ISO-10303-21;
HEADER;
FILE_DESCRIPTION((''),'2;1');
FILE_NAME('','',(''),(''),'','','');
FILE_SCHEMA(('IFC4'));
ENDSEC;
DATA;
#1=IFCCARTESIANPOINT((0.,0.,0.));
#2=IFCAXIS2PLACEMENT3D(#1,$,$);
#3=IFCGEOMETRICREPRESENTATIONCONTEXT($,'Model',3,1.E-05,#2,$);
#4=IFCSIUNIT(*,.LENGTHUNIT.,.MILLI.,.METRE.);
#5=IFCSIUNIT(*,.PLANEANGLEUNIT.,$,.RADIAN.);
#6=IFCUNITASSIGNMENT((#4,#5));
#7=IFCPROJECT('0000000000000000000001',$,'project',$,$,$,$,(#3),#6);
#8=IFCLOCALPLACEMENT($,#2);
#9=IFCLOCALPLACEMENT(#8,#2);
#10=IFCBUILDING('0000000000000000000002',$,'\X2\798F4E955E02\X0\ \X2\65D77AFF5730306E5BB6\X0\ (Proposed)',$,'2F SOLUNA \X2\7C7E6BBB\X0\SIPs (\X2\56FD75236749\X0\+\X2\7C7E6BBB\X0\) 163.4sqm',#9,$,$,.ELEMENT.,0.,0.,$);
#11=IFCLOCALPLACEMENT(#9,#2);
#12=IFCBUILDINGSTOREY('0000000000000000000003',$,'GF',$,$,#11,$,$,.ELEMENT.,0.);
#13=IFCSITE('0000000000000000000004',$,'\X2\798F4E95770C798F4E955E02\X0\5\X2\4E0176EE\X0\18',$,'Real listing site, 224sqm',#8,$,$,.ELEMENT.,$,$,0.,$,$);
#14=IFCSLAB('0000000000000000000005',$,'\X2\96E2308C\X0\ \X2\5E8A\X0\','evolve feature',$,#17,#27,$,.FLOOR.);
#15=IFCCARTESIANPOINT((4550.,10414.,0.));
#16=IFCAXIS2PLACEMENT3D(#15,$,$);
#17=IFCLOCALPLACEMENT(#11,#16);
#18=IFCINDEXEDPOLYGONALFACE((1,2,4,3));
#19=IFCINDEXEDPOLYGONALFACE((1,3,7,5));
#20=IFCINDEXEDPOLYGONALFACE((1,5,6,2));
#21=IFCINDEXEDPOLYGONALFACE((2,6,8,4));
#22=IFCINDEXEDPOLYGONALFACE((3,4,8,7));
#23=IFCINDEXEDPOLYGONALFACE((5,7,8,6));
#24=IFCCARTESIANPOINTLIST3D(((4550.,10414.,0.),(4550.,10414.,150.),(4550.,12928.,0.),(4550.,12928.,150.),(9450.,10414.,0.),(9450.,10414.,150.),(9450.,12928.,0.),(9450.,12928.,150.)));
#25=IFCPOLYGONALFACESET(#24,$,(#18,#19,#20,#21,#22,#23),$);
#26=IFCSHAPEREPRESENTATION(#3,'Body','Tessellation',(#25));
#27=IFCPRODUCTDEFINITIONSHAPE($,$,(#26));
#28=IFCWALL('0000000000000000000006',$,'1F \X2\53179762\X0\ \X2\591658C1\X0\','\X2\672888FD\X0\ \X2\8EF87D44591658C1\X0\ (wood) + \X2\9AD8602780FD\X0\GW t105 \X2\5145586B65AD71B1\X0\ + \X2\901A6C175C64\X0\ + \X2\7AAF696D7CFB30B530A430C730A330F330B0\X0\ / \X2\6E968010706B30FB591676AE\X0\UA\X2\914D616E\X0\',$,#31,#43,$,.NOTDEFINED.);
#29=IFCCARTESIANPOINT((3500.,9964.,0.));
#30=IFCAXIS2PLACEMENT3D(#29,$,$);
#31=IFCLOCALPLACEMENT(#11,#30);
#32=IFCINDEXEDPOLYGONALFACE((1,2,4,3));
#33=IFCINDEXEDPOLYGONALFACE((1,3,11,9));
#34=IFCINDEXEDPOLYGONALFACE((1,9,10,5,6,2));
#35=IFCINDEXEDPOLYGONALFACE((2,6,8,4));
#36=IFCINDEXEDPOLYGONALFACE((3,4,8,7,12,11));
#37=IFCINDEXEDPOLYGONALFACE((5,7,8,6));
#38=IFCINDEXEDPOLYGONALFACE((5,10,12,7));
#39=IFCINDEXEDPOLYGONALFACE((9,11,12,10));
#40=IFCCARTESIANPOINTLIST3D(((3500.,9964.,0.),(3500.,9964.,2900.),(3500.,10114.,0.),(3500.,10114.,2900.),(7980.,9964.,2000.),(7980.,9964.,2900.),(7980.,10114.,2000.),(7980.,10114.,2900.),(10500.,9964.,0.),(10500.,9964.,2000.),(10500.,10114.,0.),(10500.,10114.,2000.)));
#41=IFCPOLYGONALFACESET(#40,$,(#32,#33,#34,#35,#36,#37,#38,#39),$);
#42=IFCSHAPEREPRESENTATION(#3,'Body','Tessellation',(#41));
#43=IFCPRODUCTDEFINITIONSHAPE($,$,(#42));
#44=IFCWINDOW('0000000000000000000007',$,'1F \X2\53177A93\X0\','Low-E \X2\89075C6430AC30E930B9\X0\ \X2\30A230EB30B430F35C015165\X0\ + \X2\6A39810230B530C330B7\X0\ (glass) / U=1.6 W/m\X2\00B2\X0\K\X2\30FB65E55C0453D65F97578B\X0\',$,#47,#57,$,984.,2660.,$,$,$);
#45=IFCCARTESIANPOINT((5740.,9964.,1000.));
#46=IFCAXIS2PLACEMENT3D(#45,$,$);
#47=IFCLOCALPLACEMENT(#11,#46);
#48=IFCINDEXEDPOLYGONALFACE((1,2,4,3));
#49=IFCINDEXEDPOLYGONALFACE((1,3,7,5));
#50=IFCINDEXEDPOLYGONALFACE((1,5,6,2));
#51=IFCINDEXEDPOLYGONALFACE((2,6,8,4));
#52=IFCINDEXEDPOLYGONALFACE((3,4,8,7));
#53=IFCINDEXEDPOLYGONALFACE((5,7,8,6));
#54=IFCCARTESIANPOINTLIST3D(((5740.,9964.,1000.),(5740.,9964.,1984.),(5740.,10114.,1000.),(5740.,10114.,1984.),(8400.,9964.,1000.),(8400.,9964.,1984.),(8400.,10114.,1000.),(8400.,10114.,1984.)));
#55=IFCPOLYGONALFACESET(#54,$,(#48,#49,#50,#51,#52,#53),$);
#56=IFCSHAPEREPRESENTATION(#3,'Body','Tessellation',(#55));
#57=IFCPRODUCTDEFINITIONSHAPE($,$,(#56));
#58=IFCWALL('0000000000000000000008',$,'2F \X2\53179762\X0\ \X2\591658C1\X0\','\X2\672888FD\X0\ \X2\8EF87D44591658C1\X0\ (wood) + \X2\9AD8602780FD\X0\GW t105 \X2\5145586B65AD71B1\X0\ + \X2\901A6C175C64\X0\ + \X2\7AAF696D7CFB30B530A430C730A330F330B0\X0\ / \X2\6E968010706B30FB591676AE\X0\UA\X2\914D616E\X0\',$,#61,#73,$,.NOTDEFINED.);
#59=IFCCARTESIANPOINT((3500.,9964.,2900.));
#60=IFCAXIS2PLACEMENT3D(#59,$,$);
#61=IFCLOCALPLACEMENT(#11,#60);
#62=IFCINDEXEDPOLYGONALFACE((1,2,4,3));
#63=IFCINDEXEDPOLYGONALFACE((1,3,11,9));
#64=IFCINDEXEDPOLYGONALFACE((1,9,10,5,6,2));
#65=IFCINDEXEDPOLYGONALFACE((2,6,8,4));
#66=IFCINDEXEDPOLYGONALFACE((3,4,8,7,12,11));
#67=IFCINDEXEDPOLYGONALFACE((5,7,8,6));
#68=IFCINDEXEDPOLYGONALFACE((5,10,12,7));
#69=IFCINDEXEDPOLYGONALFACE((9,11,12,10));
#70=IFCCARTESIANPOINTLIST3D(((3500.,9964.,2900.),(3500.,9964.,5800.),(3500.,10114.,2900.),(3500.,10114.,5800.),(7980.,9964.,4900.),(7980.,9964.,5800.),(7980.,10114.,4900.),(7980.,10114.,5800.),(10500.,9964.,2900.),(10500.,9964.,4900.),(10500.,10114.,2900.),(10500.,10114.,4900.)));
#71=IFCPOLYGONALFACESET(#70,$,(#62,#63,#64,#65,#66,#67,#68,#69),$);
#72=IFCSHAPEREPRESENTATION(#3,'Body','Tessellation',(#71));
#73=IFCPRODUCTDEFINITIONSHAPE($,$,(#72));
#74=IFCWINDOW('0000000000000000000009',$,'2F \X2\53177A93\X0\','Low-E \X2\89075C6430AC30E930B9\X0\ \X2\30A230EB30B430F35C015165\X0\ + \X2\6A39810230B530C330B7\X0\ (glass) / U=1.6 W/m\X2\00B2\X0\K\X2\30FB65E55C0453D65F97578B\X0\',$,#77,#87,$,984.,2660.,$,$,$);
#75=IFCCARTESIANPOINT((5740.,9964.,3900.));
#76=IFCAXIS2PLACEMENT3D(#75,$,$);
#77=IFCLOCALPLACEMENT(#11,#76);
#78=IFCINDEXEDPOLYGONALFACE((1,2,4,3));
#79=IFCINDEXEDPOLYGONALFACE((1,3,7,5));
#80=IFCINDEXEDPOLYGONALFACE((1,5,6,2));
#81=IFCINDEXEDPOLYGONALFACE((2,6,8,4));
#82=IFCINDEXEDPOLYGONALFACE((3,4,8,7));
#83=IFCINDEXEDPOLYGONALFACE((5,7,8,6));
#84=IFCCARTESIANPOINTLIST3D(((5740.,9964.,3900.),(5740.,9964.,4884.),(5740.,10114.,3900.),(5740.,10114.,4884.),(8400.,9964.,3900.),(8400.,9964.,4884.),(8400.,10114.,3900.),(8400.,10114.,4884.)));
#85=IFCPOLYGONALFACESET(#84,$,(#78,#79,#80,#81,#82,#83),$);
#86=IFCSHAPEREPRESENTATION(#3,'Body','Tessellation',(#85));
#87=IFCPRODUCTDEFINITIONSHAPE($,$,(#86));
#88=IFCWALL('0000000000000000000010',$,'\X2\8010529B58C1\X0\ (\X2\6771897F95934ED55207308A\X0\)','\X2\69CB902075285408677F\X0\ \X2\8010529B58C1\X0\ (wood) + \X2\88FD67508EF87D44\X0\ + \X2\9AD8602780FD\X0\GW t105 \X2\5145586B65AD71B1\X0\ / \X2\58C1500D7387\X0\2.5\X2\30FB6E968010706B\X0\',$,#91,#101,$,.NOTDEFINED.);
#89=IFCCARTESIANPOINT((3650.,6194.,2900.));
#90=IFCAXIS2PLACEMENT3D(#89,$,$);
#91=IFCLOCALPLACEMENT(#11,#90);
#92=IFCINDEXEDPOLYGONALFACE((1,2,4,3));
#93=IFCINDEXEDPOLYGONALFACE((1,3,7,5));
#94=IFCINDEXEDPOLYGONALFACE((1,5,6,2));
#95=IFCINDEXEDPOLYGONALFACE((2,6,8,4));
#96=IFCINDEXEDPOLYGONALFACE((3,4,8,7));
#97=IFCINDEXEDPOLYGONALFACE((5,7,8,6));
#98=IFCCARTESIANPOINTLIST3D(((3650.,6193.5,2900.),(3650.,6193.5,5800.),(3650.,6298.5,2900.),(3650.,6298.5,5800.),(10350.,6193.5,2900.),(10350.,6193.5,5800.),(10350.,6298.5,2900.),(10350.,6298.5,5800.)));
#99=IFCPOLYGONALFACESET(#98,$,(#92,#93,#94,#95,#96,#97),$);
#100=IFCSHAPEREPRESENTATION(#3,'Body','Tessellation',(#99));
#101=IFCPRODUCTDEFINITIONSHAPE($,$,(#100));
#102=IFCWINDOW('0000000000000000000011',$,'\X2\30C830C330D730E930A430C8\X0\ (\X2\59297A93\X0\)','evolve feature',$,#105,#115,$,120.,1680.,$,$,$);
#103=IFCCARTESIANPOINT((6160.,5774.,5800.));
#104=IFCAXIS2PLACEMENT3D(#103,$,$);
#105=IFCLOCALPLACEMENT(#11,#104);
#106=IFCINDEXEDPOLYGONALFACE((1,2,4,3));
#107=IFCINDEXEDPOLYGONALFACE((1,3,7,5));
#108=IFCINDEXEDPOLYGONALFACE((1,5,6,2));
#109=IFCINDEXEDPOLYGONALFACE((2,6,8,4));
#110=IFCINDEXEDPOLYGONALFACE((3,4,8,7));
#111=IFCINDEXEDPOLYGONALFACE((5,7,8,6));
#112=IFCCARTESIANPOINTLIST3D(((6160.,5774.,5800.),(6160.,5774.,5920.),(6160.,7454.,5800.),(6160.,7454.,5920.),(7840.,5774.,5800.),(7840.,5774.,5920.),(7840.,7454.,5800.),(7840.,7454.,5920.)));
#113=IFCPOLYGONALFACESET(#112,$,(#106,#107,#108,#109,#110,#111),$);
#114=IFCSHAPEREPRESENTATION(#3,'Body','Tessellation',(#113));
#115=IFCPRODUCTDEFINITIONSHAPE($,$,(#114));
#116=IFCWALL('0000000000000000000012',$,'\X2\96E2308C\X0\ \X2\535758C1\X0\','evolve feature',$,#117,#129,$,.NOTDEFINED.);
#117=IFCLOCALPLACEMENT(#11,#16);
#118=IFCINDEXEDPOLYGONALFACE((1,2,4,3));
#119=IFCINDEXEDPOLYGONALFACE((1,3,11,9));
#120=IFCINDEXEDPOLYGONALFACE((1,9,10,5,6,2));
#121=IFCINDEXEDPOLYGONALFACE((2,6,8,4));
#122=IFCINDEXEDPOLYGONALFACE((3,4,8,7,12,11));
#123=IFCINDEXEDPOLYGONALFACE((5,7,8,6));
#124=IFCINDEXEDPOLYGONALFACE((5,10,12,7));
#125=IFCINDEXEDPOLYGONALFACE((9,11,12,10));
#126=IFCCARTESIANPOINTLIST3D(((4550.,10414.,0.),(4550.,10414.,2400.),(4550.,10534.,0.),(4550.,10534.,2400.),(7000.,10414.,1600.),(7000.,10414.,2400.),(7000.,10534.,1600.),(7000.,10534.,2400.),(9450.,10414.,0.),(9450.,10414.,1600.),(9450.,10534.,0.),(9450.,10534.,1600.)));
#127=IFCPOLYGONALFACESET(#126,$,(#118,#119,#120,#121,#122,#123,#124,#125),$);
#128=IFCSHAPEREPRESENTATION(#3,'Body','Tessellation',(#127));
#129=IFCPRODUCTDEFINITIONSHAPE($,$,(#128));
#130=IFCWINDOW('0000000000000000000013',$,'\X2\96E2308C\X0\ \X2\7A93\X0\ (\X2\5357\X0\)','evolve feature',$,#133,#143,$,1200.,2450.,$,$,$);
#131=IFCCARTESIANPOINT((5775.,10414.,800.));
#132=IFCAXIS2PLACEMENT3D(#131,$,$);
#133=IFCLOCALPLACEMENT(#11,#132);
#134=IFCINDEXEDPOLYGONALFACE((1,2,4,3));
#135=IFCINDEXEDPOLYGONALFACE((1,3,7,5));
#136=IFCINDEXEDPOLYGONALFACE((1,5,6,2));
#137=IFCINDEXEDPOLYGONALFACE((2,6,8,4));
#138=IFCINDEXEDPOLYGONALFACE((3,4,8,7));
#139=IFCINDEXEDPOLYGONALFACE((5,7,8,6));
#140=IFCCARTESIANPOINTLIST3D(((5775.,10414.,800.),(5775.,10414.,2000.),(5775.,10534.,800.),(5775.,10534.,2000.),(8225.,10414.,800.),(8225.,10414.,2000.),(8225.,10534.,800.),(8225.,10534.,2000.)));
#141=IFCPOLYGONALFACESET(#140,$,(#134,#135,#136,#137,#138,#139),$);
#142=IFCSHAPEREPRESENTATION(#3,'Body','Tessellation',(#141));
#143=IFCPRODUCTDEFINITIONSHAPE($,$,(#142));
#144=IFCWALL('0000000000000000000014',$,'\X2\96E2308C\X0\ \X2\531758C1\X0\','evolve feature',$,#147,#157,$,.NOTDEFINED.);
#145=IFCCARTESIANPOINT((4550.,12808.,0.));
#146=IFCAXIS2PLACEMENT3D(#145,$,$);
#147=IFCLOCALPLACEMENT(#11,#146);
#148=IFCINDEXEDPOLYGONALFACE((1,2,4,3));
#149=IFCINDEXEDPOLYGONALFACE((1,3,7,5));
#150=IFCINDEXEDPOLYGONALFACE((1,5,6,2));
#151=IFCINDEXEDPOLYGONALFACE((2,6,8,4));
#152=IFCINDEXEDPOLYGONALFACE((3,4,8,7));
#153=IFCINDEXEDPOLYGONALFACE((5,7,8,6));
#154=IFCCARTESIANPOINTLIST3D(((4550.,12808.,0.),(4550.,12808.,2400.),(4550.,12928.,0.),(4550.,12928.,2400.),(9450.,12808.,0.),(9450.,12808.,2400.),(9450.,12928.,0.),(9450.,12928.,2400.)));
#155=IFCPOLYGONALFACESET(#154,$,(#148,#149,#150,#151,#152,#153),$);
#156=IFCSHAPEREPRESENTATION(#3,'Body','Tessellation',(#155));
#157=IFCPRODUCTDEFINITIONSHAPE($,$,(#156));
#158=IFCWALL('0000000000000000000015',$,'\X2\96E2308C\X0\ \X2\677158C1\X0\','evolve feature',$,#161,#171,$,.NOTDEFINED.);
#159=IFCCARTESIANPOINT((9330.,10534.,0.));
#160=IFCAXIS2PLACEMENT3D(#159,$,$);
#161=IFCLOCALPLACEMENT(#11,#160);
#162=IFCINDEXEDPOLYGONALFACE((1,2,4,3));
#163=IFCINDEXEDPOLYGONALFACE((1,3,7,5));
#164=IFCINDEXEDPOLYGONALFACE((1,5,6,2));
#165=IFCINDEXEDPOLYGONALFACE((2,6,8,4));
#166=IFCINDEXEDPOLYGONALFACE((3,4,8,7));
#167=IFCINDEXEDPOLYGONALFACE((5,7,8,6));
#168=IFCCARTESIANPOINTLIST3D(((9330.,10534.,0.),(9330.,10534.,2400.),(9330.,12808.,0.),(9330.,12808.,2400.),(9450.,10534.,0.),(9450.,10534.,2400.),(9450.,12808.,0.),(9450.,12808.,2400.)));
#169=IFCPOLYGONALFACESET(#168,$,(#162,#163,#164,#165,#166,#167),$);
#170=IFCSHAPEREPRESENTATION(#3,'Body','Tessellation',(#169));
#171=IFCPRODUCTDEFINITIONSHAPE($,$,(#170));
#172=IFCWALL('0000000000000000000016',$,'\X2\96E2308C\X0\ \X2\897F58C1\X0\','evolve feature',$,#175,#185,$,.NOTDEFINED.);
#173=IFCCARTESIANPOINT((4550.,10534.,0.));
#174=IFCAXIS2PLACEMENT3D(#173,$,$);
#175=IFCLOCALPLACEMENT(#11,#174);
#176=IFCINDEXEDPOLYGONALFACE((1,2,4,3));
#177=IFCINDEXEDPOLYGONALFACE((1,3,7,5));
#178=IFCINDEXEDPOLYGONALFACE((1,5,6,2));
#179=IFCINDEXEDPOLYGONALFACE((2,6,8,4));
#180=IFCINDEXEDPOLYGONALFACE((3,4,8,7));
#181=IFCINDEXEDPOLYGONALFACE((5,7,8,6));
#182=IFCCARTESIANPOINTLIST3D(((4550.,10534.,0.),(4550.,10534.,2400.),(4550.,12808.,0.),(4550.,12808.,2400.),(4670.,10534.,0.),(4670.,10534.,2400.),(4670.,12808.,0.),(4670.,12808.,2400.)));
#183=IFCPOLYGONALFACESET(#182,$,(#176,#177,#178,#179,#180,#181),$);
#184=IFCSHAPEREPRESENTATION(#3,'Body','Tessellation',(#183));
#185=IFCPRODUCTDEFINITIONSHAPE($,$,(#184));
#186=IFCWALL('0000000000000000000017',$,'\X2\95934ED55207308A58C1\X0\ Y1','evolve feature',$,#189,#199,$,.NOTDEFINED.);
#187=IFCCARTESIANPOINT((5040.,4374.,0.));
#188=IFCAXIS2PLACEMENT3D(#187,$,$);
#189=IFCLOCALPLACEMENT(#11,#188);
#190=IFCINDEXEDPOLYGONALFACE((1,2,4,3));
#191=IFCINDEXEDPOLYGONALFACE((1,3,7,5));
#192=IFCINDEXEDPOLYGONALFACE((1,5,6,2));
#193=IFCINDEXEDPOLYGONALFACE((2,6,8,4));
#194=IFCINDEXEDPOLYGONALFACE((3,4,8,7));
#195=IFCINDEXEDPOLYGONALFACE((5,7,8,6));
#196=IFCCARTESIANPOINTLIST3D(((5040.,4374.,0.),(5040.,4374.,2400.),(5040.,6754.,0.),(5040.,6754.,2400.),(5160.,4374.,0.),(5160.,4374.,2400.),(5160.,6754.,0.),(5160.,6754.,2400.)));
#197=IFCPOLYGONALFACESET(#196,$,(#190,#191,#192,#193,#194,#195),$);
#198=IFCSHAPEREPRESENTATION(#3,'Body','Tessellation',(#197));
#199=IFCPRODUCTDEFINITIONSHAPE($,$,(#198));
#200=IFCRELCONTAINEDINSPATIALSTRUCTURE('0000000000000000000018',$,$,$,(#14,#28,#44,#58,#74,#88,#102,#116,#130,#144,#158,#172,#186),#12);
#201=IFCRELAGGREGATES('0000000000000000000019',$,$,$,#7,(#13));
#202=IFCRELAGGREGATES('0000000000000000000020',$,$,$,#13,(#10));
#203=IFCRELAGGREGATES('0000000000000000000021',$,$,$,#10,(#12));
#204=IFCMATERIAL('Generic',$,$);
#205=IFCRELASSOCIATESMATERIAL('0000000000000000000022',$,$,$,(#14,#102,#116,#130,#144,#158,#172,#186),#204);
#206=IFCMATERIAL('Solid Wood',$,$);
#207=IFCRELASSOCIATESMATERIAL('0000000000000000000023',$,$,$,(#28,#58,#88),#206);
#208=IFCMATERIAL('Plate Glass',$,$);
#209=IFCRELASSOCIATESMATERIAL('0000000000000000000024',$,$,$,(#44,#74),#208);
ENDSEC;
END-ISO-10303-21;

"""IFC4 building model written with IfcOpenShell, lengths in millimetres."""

from ifc_helpers import new_model, si_unit, frame, frame_2d, origin, place, context, project, spatial, rectangle, extrude, material, element, fill, save


model = new_model("IFC4")

# Units and contexts
model_context = context("Model", 3, precision=1e-05, world=origin())
ifc_project = project(units=[si_unit("LENGTHUNIT", "METRE", prefix="MILLI"), si_unit("PLANEANGLEUNIT", "RADIAN")], contexts=[model_context])

# Site, building, storey
site_placement = place(None, origin())
site = spatial("IfcSite", under=ifc_project, at=site_placement, Name="福井県福井市5丁目18", ObjectType="Real listing site, 224sqm", CompositionType="ELEMENT", RefElevation=0.0)
building_placement = place(site_placement, origin())
building = spatial("IfcBuilding", under=site, at=building_placement, Name="福井市 旗竿地の家 (Proposed)", ObjectType="2F SOLUNA 籾殻SIPs (国産杉+籾殻) 163.4sqm", CompositionType="ELEMENT", ElevationOfRefHeight=0.0, ElevationOfTerrain=0.0)
storey_placement = place(building_placement, origin())
storey = spatial("IfcBuildingStorey", under=building, at=storey_placement, Name="GF", CompositionType="ELEMENT", Elevation=0.0)

# Slab
ifc_material_1 = material(Name="Generic")
slab_placement = place(storey_placement, frame((4550.0, 10414.0, 0.0)))
element("IfcSlab", 1, at=slab_placement, inside=storey, material=ifc_material_1, Name="離れ 床", Description="evolve feature", PredefinedType="FLOOR", context=model_context, shape_type="SweptSolid", body=[
    extrude(rectangle(XDim=4900.0, YDim=2514.0, at=frame_2d((2450.0, 1257.0))), frame((4550.0, 10414.0, 0.0)), (0.0, 0.0, 1.0), 150.0),
])

# Wall, opening, window
ifc_material_2 = material(Name="Solid Wood")
wall_1_placement = place(storey_placement, frame((3500.0, 9964.0, 0.0)))
wall_1 = element("IfcWall", 2, at=wall_1_placement, inside=storey, material=ifc_material_2, Name="1F 北面 外壁", Description="木製 軸組外壁 (wood) + 高性能GW t105 充填断熱 + 通気層 + 窯業系サイディング / 準耐火・外皮UA配慮", PredefinedType="NOTDEFINED", context=model_context, shape_type="SweptSolid", body=[
    extrude(rectangle(XDim=7000.0, YDim=150.0, at=frame_2d((3500.0, 75.0))), frame((3500.0, 9964.0, 0.0)), (0.0, 0.0, 1.0), 2900.0),
])
opening_1_placement = place(storey_placement, frame((5740.0, 9964.0, 1000.0)))
opening_1 = element("IfcOpeningElement", 3, at=opening_1_placement, cuts=wall_1, PredefinedType="NOTDEFINED", context=model_context, shape_type="SweptSolid", body=[
    extrude(rectangle(XDim=2660.0, YDim=150.0, at=frame_2d((1330.0, 75.0))), frame((5740.0, 9964.0, 1000.0)), (0.0, 0.0, 1.0), 984.0),
])
ifc_material_3 = material(Name="Plate Glass")
window_1_placement = place(storey_placement, frame((5740.0, 9964.0, 1000.0)))
window_1 = element("IfcWindow", 4, at=window_1_placement, inside=storey, material=ifc_material_3, Name="1F 北窓", Description="Low-E 複層ガラス アルゴン封入 + 樹脂サッシ (glass) / U=1.6 W/m²K・日射取得型", OverallHeight=984.0, OverallWidth=2660.0, context=model_context, shape_type="SweptSolid", body=[
    extrude(rectangle(XDim=2660.0, YDim=150.0, at=frame_2d((1330.0, 75.0))), frame((5740.0, 9964.0, 1000.0)), (0.0, 0.0, 1.0), 984.0),
])
fill(opening_1, window_1)

# Wall, opening, window
wall_2_placement = place(storey_placement, frame((3500.0, 9964.0, 2900.0)))
wall_2 = element("IfcWall", 5, at=wall_2_placement, inside=storey, material=ifc_material_2, Name="2F 北面 外壁", Description="木製 軸組外壁 (wood) + 高性能GW t105 充填断熱 + 通気層 + 窯業系サイディング / 準耐火・外皮UA配慮", PredefinedType="NOTDEFINED", context=model_context, shape_type="SweptSolid", body=[
    extrude(rectangle(XDim=7000.0, YDim=150.0, at=frame_2d((3500.0, 75.0))), frame((3500.0, 9964.0, 2900.0)), (0.0, 0.0, 1.0), 2900.0),
])
opening_2_placement = place(storey_placement, frame((5740.0, 9964.0, 3900.0)))
opening_2 = element("IfcOpeningElement", 6, at=opening_2_placement, cuts=wall_2, PredefinedType="NOTDEFINED", context=model_context, shape_type="SweptSolid", body=[
    extrude(rectangle(XDim=2660.0, YDim=150.0, at=frame_2d((1330.0, 75.0))), frame((5740.0, 9964.0, 3900.0)), (0.0, 0.0, 1.0), 984.0),
])
window_2_placement = place(storey_placement, frame((5740.0, 9964.0, 3900.0)))
window_2 = element("IfcWindow", 7, at=window_2_placement, inside=storey, material=ifc_material_3, Name="2F 北窓", Description="Low-E 複層ガラス アルゴン封入 + 樹脂サッシ (glass) / U=1.6 W/m²K・日射取得型", OverallHeight=984.0, OverallWidth=2660.0, context=model_context, shape_type="SweptSolid", body=[
    extrude(rectangle(XDim=2660.0, YDim=150.0, at=frame_2d((1330.0, 75.0))), frame((5740.0, 9964.0, 3900.0)), (0.0, 0.0, 1.0), 984.0),
])
fill(opening_2, window_2)

# Wall
wall_3_placement = place(storey_placement, frame((3650.0, 6194.0, 2900.0)))
element("IfcWall", 8, at=wall_3_placement, inside=storey, material=ifc_material_2, Name="耐力壁 (東西間仕切り)", Description="構造用合板 耐力壁 (wood) + 製材軸組 + 高性能GW t105 充填断熱 / 壁倍率2.5・準耐火", PredefinedType="NOTDEFINED", context=model_context, shape_type="SweptSolid", body=[
    extrude(rectangle(XDim=6700.0, YDim=105.0, at=frame_2d((3350.0, 52.0))), frame((3650.0, 6194.0, 2900.0)), (0.0, 0.0, 1.0), 2900.0),
])

# Window
window_3_placement = place(storey_placement, frame((6160.0, 5774.0, 5800.0)))
element("IfcWindow", 9, at=window_3_placement, inside=storey, material=ifc_material_1, Name="トップライト (天窓)", Description="evolve feature", OverallHeight=120.0, OverallWidth=1680.0, context=model_context, shape_type="SweptSolid", body=[
    extrude(rectangle(XDim=1680.0, YDim=1680.0, at=frame_2d((840.0, 840.0))), frame((6160.0, 5774.0, 5800.0)), (0.0, 0.0, 1.0), 120.0),
])

# Wall, opening, window
wall_4_placement = place(storey_placement, frame((4550.0, 10414.0, 0.0)))
wall_4 = element("IfcWall", 10, at=wall_4_placement, inside=storey, material=ifc_material_1, Name="離れ 南壁", Description="evolve feature", PredefinedType="NOTDEFINED", context=model_context, shape_type="SweptSolid", body=[
    extrude(rectangle(XDim=4900.0, YDim=120.0, at=frame_2d((2450.0, 60.0))), frame((4550.0, 10414.0, 0.0)), (0.0, 0.0, 1.0), 2400.0),
])
opening_3_placement = place(storey_placement, frame((5775.0, 10414.0, 800.0)))
opening_3 = element("IfcOpeningElement", 11, at=opening_3_placement, cuts=wall_4, PredefinedType="NOTDEFINED", context=model_context, shape_type="SweptSolid", body=[
    extrude(rectangle(XDim=2450.0, YDim=120.0, at=frame_2d((1225.0, 60.0))), frame((5775.0, 10414.0, 800.0)), (0.0, 0.0, 1.0), 1200.0),
])
window_4_placement = place(storey_placement, frame((5775.0, 10414.0, 800.0)))
window_4 = element("IfcWindow", 12, at=window_4_placement, inside=storey, material=ifc_material_1, Name="離れ 窓 (南)", Description="evolve feature", OverallHeight=1200.0, OverallWidth=2450.0, context=model_context, shape_type="SweptSolid", body=[
    extrude(rectangle(XDim=2450.0, YDim=120.0, at=frame_2d((1225.0, 60.0))), frame((5775.0, 10414.0, 800.0)), (0.0, 0.0, 1.0), 1200.0),
])
fill(opening_3, window_4)

# Walls
wall_5_placement = place(storey_placement, frame((4550.0, 12808.0, 0.0)))
element("IfcWall", 13, at=wall_5_placement, inside=storey, material=ifc_material_1, Name="離れ 北壁", Description="evolve feature", PredefinedType="NOTDEFINED", context=model_context, shape_type="SweptSolid", body=[
    extrude(rectangle(XDim=4900.0, YDim=120.0, at=frame_2d((2450.0, 60.0))), frame((4550.0, 12808.0, 0.0)), (0.0, 0.0, 1.0), 2400.0),
])
wall_6_placement = place(storey_placement, frame((9330.0, 10534.0, 0.0)))
element("IfcWall", 14, at=wall_6_placement, inside=storey, material=ifc_material_1, Name="離れ 東壁", Description="evolve feature", PredefinedType="NOTDEFINED", context=model_context, shape_type="SweptSolid", body=[
    extrude(rectangle(XDim=120.0, YDim=2274.0, at=frame_2d((60.0, 1137.0))), frame((9330.0, 10534.0, 0.0)), (0.0, 0.0, 1.0), 2400.0),
])
wall_7_placement = place(storey_placement, frame((4550.0, 10534.0, 0.0)))
element("IfcWall", 15, at=wall_7_placement, inside=storey, material=ifc_material_1, Name="離れ 西壁", Description="evolve feature", PredefinedType="NOTDEFINED", context=model_context, shape_type="SweptSolid", body=[
    extrude(rectangle(XDim=120.0, YDim=2274.0, at=frame_2d((60.0, 1137.0))), frame((4550.0, 10534.0, 0.0)), (0.0, 0.0, 1.0), 2400.0),
])
wall_8_placement = place(storey_placement, frame((5040.0, 4374.0, 0.0)))
element("IfcWall", 16, at=wall_8_placement, inside=storey, material=ifc_material_1, Name="間仕切り壁 Y1", Description="evolve feature", PredefinedType="NOTDEFINED", context=model_context, shape_type="SweptSolid", body=[
    extrude(rectangle(XDim=120.0, YDim=2380.0, at=frame_2d((60.0, 1190.0))), frame((5040.0, 4374.0, 0.0)), (0.0, 0.0, 1.0), 2400.0),
])

save(model, "model.ifc")
